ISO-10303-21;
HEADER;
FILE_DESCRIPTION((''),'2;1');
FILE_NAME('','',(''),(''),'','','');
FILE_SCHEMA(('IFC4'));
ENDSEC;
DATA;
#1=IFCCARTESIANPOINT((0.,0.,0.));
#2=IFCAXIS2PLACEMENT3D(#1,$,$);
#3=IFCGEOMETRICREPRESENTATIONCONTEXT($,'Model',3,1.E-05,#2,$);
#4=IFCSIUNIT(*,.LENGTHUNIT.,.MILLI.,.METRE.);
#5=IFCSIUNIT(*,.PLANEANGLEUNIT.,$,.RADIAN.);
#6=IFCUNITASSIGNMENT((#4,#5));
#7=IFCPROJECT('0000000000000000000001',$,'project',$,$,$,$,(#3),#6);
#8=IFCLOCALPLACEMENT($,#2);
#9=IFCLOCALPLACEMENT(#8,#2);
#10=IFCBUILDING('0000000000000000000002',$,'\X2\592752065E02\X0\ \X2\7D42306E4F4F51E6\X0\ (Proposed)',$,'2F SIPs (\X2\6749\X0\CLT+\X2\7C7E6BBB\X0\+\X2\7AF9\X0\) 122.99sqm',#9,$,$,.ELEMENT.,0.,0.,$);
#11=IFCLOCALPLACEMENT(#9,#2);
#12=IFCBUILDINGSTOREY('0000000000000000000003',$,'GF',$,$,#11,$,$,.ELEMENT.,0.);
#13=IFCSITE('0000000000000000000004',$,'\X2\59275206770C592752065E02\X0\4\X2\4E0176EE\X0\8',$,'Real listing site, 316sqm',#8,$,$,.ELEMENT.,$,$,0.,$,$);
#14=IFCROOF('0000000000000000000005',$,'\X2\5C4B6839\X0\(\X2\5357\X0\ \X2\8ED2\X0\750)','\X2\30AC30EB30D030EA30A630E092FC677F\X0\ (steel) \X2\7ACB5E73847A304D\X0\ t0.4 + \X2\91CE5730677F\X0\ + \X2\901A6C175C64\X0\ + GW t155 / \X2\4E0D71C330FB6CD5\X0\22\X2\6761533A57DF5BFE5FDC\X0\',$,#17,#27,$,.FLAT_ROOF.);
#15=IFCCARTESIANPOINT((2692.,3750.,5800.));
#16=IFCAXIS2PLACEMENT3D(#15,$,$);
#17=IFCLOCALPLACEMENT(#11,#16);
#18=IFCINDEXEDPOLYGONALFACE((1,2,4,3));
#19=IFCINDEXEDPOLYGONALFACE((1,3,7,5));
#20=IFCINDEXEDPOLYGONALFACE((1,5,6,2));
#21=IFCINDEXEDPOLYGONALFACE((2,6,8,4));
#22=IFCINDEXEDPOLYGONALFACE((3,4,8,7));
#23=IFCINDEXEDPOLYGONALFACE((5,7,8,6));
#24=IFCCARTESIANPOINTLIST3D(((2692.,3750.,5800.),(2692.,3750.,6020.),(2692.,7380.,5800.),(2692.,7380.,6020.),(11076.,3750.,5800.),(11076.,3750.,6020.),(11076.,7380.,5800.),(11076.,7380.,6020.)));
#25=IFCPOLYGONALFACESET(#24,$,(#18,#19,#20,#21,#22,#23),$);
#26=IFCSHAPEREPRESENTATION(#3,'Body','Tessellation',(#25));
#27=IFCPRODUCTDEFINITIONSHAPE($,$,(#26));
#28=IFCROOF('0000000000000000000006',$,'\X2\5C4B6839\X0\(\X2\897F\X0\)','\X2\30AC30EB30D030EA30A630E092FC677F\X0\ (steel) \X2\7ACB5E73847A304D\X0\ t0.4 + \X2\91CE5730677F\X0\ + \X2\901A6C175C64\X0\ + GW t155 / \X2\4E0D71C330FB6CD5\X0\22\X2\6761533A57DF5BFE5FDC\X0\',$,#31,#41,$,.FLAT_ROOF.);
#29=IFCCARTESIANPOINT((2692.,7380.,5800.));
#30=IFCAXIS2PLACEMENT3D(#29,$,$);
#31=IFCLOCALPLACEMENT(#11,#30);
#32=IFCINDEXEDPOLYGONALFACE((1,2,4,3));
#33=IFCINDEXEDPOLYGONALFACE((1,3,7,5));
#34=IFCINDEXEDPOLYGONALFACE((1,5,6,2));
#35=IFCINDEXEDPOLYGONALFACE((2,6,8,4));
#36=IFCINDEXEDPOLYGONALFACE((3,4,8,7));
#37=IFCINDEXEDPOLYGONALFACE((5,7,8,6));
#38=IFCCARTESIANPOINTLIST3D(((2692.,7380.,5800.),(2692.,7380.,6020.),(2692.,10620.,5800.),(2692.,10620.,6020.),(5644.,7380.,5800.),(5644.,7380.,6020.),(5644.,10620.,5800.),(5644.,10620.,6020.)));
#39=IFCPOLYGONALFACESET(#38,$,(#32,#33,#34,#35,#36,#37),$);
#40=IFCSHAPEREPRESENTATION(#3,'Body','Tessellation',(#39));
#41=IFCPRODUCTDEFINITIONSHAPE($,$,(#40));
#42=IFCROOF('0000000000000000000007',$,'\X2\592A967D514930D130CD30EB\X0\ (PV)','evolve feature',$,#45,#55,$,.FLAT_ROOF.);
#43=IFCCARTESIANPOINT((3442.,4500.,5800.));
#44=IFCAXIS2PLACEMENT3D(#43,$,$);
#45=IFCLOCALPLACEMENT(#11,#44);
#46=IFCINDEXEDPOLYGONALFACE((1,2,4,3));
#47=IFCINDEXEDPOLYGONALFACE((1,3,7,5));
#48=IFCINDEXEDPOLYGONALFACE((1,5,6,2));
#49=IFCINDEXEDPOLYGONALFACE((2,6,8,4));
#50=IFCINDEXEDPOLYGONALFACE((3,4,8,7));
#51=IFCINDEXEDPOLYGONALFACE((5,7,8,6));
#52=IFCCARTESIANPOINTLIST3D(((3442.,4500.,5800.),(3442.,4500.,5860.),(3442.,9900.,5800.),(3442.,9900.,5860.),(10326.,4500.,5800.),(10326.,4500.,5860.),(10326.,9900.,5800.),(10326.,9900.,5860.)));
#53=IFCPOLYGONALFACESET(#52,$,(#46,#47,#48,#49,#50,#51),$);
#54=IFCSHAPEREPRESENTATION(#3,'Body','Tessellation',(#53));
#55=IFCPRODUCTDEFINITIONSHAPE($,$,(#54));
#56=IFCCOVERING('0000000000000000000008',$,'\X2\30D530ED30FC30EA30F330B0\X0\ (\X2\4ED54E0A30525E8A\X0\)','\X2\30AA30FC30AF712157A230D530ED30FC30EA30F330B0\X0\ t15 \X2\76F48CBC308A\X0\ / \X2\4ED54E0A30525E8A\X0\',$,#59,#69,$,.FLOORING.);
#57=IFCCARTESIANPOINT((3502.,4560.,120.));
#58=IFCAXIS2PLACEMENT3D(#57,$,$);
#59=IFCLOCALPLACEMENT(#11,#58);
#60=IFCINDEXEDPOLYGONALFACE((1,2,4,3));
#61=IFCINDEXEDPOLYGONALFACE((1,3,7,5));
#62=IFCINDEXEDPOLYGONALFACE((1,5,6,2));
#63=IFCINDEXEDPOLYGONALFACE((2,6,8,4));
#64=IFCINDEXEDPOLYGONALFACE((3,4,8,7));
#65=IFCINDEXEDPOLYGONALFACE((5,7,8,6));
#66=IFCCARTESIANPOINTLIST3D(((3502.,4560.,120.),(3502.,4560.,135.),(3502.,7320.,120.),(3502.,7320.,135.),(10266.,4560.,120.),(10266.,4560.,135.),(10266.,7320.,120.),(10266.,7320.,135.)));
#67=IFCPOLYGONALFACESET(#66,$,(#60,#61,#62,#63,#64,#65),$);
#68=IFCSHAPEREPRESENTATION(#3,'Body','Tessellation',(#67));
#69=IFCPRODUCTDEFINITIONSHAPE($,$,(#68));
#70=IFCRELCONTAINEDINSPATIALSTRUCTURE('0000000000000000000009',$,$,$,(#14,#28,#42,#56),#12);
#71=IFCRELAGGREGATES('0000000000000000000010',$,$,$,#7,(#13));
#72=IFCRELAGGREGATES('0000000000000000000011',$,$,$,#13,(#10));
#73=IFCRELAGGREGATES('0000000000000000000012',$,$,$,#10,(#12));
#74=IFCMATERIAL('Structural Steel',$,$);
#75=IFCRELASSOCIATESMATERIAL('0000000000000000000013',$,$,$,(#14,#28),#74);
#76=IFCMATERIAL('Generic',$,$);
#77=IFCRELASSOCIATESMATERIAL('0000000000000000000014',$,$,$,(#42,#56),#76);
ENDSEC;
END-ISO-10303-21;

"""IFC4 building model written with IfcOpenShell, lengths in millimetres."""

from ifc_helpers import new_model, si_unit, frame, frame_2d, origin, place, context, project, spatial, rectangle, extrude, material, element, save


model = new_model("IFC4")

# Units and contexts
model_context = context("Model", 3, precision=1e-05, world=origin())
ifc_project = project(units=[si_unit("LENGTHUNIT", "METRE", prefix="MILLI"), si_unit("PLANEANGLEUNIT", "RADIAN")], contexts=[model_context])

# Site, building, storey
site_placement = place(None, origin())
site = spatial("IfcSite", under=ifc_project, at=site_placement, Name="大分県大分市4丁目8", ObjectType="Real listing site, 316sqm", CompositionType="ELEMENT", RefElevation=0.0)
building_placement = place(site_placement, origin())
building = spatial("IfcBuilding", under=site, at=building_placement, Name="大分市 終の住処 (Proposed)", ObjectType="2F SIPs (杉CLT+籾殻+竹) 122.99sqm", CompositionType="ELEMENT", ElevationOfRefHeight=0.0, ElevationOfTerrain=0.0)
storey_placement = place(building_placement, origin())
storey = spatial("IfcBuildingStorey", under=building, at=storey_placement, Name="GF", CompositionType="ELEMENT", Elevation=0.0)

# Shared definitions
ifc_material_1 = material(Name="Generic")

# Roofs
ifc_material_2 = material(Name="Structural Steel")
roof_1_placement = place(storey_placement, frame((2692.0, 3750.0, 5800.0)))
element("IfcRoof", 1, at=roof_1_placement, inside=storey, material=ifc_material_2, Name="屋根(南 軒750)", Description="ガルバリウム鋼板 (steel) 立平葺き t0.4 + 野地板 + 通気層 + GW t155 / 不燃・法22条区域対応", PredefinedType="FLAT_ROOF", context=model_context, shape_type="SweptSolid", body=[
    extrude(rectangle(XDim=8384.0, YDim=3630.0, at=frame_2d((4192.0, 1815.0))), frame((2692.0, 3750.0, 5800.0)), (0.0, 0.0, 1.0), 220.0),
])
roof_2_placement = place(storey_placement, frame((2692.0, 7380.0, 5800.0)))
element("IfcRoof", 2, at=roof_2_placement, inside=storey, material=ifc_material_2, Name="屋根(西)", Description="ガルバリウム鋼板 (steel) 立平葺き t0.4 + 野地板 + 通気層 + GW t155 / 不燃・法22条区域対応", PredefinedType="FLAT_ROOF", context=model_context, shape_type="SweptSolid", body=[
    extrude(rectangle(XDim=2952.0, YDim=3240.0, at=frame_2d((1476.0, 1620.0))), frame((2692.0, 7380.0, 5800.0)), (0.0, 0.0, 1.0), 220.0),
])
roof_3_placement = place(storey_placement, frame((3442.0, 4500.0, 5800.0)))
element("IfcRoof", 3, at=roof_3_placement, inside=storey, material=ifc_material_1, Name="太陽光パネル (PV)", Description="evolve feature", PredefinedType="FLAT_ROOF", context=model_context, shape_type="SweptSolid", body=[
    extrude(rectangle(XDim=6884.0, YDim=5400.0, at=frame_2d((3442.0, 2700.0))), frame((3442.0, 4500.0, 5800.0)), (0.0, 0.0, 1.0), 60.0),
])

# Covering
covering_placement = place(storey_placement, frame((3502.0, 4560.0, 120.0)))
element("IfcCovering", 4, at=covering_placement, inside=storey, material=ifc_material_1, Name="フローリング (仕上げ床)", Description="オーク無垢フローリング t15 直貼り / 仕上げ床", PredefinedType="FLOORING", context=model_context, shape_type="SweptSolid", body=[
    extrude(rectangle(XDim=6764.0, YDim=2760.0, at=frame_2d((3382.0, 1380.0))), frame((3502.0, 4560.0, 120.0)), (0.0, 0.0, 1.0), 15.0),
])

save(model, "model.ifc")
